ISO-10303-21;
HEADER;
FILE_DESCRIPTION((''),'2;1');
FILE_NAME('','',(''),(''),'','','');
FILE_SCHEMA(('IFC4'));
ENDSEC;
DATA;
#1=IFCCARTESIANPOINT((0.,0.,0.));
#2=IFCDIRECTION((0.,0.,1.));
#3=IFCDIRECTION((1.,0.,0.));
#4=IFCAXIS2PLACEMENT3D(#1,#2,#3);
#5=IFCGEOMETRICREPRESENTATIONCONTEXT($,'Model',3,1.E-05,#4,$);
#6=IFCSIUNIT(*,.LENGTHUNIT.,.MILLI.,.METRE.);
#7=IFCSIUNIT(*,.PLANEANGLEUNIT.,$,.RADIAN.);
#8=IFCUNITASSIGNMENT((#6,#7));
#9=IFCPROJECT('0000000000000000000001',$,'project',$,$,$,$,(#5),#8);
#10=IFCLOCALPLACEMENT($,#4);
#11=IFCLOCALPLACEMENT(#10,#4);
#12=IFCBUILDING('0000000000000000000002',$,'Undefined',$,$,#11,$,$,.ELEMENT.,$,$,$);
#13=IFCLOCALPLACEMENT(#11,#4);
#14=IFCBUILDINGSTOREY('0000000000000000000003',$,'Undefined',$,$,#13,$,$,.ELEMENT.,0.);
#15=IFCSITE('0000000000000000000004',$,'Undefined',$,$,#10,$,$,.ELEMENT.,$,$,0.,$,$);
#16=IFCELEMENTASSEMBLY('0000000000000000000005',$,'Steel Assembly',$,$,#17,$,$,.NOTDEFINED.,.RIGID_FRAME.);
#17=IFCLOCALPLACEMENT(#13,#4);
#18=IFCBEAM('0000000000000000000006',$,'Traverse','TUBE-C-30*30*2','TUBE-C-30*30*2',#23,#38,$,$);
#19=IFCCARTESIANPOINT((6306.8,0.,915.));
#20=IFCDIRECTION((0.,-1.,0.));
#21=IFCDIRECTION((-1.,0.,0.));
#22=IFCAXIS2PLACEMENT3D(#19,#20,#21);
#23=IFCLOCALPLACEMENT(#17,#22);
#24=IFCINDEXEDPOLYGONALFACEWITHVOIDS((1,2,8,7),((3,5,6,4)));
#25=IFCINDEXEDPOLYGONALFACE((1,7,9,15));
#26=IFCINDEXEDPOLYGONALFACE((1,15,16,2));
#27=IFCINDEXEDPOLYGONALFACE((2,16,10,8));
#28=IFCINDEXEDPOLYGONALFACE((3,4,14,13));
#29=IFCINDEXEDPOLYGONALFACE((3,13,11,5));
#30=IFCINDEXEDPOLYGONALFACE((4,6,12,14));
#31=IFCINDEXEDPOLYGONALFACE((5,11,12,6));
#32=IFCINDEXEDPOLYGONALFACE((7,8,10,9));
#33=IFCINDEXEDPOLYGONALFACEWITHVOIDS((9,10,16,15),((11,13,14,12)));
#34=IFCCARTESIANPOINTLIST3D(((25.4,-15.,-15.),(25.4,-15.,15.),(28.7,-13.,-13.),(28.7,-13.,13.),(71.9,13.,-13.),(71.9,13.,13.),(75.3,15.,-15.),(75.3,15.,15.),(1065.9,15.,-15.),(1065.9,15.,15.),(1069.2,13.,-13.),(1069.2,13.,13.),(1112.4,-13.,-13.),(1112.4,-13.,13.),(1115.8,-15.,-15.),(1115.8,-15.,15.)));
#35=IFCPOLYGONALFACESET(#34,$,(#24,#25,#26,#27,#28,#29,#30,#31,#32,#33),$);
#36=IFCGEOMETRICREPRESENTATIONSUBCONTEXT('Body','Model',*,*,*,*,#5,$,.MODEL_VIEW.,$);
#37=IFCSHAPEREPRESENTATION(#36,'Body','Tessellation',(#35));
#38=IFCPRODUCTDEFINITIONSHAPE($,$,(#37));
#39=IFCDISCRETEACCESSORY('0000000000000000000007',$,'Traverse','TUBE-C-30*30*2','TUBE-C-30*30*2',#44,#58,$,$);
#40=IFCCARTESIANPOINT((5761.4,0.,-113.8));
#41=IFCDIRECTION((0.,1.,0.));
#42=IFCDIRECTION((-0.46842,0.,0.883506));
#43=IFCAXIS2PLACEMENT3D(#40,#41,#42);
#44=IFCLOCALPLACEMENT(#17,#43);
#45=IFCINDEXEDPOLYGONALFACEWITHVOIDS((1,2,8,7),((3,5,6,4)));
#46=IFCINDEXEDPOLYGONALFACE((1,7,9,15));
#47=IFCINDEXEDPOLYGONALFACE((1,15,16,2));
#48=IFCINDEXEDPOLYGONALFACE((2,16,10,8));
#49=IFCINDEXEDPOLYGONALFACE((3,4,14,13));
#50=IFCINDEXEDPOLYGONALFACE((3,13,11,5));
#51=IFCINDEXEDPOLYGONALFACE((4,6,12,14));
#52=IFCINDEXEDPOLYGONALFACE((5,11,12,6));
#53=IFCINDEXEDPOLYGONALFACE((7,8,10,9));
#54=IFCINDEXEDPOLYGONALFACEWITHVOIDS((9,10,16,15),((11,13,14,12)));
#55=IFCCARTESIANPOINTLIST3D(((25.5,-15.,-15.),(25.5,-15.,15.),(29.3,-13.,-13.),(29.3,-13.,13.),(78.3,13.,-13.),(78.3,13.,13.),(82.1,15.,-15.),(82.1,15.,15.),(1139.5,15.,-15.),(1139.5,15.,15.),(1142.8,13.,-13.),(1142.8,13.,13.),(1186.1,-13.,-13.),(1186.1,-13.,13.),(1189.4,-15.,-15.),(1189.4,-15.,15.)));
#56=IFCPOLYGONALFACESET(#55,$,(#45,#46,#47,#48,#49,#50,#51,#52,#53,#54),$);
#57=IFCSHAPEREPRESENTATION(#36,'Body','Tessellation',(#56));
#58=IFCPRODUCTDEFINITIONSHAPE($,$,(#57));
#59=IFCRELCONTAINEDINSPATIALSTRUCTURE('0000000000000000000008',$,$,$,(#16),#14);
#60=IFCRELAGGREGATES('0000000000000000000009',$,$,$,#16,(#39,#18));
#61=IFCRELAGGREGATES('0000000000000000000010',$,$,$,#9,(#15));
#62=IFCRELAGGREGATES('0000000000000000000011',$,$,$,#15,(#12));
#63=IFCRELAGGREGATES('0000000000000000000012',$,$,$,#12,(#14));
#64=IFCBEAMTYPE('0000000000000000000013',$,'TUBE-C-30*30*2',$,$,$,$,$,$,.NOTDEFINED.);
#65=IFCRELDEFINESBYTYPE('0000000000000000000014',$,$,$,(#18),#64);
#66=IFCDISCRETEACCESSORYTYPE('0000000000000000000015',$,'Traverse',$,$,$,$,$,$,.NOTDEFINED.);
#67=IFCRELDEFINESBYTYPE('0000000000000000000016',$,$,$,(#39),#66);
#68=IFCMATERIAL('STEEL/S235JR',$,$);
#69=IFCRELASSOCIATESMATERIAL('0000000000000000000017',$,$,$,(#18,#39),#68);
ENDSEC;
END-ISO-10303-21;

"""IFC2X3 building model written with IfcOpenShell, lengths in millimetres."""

from ifc_helpers import new_model, si_unit, frame, origin_with_axes, origin_2d_with_axis, place, context, subcontext, project, spatial, hollow_rectangle, extrude, clip, halfspace, material, type_object, element, aggregate, save


model = new_model("IFC2X3")

# Units and contexts
model_context = context("Model", 3, precision=1e-05, world=origin_with_axes())
body_context = subcontext(model_context, "Body", "Model", "MODEL_VIEW")
ifc_project = project(units=[si_unit("LENGTHUNIT", "METRE", prefix="MILLI"), si_unit("PLANEANGLEUNIT", "RADIAN")], contexts=[model_context])

# Site, building, storey
site_placement = place(None, origin_with_axes())
site = spatial("IfcSite", under=ifc_project, at=site_placement, Name="Undefined", CompositionType="ELEMENT", RefElevation=0.0)
building_placement = place(site_placement, origin_with_axes())
building = spatial("IfcBuilding", under=site, at=building_placement, Name="Undefined", CompositionType="ELEMENT")
storey_placement = place(building_placement, origin_with_axes())
storey = spatial("IfcBuildingStorey", under=building, at=storey_placement, Name="Undefined", CompositionType="ELEMENT", Elevation=0.0)

# Element assembly, beam
ifc_material = material(Name="STEEL/S235JR")
beam_type = type_object("IfcBeamType", Name="TUBE-C-30*30*2", PredefinedType="NOTDEFINED")
assembly_1_placement = place(storey_placement, origin_with_axes())
assembly_1 = element("IfcElementAssembly", 1, at=assembly_1_placement, inside=storey, Name="Steel Assembly", AssemblyPlace="NOTDEFINED", PredefinedType="RIGID_FRAME")
beam_1_placement = place(assembly_1_placement, frame((6306.8, 0.0, 915.0), z_axis=(0.0, -1.0, 0.0), x_axis=(-1.0, 0.0, 0.0)))
beam_1 = element("IfcBeam", 2, at=beam_1_placement, type_object=beam_type, material=ifc_material, Name="Traverse", Description="TUBE-C-30*30*2", ObjectType="TUBE-C-30*30*2", context=body_context, shape_type="Clipping", body=[
    clip(clip(extrude(hollow_rectangle(XDim=30.0, YDim=30.0, WallThickness=2.0, at=origin_2d_with_axis()), frame((1141.2, 0.0, 0.0), z_axis=(-1.0, 0.0, 0.0), x_axis=(0.0, -1.0, 0.0)), (0.0, 0.0, 1.0), 1141.2), halfspace(frame((1065.9, 15.0, 0.0), z_axis=(0.515548, 0.856861, 0.000003), x_axis=(0.000005, 0.0, -1.0)), False)), halfspace(frame((75.3, 15.0, 0.0), z_axis=(0.515548, -0.856861, 0.000003), x_axis=(0.000005, 0.0, -1.0)), True)),
])

# Discrete accessory
discrete_accessory_type_1 = type_object("IfcDiscreteAccessoryType", Name="Traverse")
discrete_accessory_1_placement = place(assembly_1_placement, frame((5761.4, 0.0, -113.8), z_axis=(0.0, 1.0, 0.0), x_axis=(-0.46842, 0.0, 0.883506)))
discrete_accessory_1 = element("IfcDiscreteAccessory", 3, at=discrete_accessory_1_placement, type_object=discrete_accessory_type_1, material=ifc_material, Name="Traverse", Description="TUBE-C-30*30*2", ObjectType="TUBE-C-30*30*2", context=body_context, shape_type="Clipping", body=[
    clip(clip(extrude(hollow_rectangle(XDim=30.0, YDim=30.0, WallThickness=2.0, at=origin_2d_with_axis()), frame((1218.2, 0.0, 0.0), z_axis=(-1.0, 0.0, 0.0), x_axis=(0.0, -1.0, 0.0)), (0.0, 0.0, 1.0), 1218.2), halfspace(frame((1139.5, 15.0, 0.0), z_axis=(-0.515548, -0.856861, -0.000003), x_axis=(0.000003, -0.000005, 1.0)), True)), halfspace(frame((82.1, 15.0, 0.0), z_axis=(-0.46842, 0.883506, 0.000005), x_axis=(0.000003, -0.000005, 1.0)), False)),
])
aggregate(assembly_1, [discrete_accessory_1, beam_1])

save(model, "model.ifc")
